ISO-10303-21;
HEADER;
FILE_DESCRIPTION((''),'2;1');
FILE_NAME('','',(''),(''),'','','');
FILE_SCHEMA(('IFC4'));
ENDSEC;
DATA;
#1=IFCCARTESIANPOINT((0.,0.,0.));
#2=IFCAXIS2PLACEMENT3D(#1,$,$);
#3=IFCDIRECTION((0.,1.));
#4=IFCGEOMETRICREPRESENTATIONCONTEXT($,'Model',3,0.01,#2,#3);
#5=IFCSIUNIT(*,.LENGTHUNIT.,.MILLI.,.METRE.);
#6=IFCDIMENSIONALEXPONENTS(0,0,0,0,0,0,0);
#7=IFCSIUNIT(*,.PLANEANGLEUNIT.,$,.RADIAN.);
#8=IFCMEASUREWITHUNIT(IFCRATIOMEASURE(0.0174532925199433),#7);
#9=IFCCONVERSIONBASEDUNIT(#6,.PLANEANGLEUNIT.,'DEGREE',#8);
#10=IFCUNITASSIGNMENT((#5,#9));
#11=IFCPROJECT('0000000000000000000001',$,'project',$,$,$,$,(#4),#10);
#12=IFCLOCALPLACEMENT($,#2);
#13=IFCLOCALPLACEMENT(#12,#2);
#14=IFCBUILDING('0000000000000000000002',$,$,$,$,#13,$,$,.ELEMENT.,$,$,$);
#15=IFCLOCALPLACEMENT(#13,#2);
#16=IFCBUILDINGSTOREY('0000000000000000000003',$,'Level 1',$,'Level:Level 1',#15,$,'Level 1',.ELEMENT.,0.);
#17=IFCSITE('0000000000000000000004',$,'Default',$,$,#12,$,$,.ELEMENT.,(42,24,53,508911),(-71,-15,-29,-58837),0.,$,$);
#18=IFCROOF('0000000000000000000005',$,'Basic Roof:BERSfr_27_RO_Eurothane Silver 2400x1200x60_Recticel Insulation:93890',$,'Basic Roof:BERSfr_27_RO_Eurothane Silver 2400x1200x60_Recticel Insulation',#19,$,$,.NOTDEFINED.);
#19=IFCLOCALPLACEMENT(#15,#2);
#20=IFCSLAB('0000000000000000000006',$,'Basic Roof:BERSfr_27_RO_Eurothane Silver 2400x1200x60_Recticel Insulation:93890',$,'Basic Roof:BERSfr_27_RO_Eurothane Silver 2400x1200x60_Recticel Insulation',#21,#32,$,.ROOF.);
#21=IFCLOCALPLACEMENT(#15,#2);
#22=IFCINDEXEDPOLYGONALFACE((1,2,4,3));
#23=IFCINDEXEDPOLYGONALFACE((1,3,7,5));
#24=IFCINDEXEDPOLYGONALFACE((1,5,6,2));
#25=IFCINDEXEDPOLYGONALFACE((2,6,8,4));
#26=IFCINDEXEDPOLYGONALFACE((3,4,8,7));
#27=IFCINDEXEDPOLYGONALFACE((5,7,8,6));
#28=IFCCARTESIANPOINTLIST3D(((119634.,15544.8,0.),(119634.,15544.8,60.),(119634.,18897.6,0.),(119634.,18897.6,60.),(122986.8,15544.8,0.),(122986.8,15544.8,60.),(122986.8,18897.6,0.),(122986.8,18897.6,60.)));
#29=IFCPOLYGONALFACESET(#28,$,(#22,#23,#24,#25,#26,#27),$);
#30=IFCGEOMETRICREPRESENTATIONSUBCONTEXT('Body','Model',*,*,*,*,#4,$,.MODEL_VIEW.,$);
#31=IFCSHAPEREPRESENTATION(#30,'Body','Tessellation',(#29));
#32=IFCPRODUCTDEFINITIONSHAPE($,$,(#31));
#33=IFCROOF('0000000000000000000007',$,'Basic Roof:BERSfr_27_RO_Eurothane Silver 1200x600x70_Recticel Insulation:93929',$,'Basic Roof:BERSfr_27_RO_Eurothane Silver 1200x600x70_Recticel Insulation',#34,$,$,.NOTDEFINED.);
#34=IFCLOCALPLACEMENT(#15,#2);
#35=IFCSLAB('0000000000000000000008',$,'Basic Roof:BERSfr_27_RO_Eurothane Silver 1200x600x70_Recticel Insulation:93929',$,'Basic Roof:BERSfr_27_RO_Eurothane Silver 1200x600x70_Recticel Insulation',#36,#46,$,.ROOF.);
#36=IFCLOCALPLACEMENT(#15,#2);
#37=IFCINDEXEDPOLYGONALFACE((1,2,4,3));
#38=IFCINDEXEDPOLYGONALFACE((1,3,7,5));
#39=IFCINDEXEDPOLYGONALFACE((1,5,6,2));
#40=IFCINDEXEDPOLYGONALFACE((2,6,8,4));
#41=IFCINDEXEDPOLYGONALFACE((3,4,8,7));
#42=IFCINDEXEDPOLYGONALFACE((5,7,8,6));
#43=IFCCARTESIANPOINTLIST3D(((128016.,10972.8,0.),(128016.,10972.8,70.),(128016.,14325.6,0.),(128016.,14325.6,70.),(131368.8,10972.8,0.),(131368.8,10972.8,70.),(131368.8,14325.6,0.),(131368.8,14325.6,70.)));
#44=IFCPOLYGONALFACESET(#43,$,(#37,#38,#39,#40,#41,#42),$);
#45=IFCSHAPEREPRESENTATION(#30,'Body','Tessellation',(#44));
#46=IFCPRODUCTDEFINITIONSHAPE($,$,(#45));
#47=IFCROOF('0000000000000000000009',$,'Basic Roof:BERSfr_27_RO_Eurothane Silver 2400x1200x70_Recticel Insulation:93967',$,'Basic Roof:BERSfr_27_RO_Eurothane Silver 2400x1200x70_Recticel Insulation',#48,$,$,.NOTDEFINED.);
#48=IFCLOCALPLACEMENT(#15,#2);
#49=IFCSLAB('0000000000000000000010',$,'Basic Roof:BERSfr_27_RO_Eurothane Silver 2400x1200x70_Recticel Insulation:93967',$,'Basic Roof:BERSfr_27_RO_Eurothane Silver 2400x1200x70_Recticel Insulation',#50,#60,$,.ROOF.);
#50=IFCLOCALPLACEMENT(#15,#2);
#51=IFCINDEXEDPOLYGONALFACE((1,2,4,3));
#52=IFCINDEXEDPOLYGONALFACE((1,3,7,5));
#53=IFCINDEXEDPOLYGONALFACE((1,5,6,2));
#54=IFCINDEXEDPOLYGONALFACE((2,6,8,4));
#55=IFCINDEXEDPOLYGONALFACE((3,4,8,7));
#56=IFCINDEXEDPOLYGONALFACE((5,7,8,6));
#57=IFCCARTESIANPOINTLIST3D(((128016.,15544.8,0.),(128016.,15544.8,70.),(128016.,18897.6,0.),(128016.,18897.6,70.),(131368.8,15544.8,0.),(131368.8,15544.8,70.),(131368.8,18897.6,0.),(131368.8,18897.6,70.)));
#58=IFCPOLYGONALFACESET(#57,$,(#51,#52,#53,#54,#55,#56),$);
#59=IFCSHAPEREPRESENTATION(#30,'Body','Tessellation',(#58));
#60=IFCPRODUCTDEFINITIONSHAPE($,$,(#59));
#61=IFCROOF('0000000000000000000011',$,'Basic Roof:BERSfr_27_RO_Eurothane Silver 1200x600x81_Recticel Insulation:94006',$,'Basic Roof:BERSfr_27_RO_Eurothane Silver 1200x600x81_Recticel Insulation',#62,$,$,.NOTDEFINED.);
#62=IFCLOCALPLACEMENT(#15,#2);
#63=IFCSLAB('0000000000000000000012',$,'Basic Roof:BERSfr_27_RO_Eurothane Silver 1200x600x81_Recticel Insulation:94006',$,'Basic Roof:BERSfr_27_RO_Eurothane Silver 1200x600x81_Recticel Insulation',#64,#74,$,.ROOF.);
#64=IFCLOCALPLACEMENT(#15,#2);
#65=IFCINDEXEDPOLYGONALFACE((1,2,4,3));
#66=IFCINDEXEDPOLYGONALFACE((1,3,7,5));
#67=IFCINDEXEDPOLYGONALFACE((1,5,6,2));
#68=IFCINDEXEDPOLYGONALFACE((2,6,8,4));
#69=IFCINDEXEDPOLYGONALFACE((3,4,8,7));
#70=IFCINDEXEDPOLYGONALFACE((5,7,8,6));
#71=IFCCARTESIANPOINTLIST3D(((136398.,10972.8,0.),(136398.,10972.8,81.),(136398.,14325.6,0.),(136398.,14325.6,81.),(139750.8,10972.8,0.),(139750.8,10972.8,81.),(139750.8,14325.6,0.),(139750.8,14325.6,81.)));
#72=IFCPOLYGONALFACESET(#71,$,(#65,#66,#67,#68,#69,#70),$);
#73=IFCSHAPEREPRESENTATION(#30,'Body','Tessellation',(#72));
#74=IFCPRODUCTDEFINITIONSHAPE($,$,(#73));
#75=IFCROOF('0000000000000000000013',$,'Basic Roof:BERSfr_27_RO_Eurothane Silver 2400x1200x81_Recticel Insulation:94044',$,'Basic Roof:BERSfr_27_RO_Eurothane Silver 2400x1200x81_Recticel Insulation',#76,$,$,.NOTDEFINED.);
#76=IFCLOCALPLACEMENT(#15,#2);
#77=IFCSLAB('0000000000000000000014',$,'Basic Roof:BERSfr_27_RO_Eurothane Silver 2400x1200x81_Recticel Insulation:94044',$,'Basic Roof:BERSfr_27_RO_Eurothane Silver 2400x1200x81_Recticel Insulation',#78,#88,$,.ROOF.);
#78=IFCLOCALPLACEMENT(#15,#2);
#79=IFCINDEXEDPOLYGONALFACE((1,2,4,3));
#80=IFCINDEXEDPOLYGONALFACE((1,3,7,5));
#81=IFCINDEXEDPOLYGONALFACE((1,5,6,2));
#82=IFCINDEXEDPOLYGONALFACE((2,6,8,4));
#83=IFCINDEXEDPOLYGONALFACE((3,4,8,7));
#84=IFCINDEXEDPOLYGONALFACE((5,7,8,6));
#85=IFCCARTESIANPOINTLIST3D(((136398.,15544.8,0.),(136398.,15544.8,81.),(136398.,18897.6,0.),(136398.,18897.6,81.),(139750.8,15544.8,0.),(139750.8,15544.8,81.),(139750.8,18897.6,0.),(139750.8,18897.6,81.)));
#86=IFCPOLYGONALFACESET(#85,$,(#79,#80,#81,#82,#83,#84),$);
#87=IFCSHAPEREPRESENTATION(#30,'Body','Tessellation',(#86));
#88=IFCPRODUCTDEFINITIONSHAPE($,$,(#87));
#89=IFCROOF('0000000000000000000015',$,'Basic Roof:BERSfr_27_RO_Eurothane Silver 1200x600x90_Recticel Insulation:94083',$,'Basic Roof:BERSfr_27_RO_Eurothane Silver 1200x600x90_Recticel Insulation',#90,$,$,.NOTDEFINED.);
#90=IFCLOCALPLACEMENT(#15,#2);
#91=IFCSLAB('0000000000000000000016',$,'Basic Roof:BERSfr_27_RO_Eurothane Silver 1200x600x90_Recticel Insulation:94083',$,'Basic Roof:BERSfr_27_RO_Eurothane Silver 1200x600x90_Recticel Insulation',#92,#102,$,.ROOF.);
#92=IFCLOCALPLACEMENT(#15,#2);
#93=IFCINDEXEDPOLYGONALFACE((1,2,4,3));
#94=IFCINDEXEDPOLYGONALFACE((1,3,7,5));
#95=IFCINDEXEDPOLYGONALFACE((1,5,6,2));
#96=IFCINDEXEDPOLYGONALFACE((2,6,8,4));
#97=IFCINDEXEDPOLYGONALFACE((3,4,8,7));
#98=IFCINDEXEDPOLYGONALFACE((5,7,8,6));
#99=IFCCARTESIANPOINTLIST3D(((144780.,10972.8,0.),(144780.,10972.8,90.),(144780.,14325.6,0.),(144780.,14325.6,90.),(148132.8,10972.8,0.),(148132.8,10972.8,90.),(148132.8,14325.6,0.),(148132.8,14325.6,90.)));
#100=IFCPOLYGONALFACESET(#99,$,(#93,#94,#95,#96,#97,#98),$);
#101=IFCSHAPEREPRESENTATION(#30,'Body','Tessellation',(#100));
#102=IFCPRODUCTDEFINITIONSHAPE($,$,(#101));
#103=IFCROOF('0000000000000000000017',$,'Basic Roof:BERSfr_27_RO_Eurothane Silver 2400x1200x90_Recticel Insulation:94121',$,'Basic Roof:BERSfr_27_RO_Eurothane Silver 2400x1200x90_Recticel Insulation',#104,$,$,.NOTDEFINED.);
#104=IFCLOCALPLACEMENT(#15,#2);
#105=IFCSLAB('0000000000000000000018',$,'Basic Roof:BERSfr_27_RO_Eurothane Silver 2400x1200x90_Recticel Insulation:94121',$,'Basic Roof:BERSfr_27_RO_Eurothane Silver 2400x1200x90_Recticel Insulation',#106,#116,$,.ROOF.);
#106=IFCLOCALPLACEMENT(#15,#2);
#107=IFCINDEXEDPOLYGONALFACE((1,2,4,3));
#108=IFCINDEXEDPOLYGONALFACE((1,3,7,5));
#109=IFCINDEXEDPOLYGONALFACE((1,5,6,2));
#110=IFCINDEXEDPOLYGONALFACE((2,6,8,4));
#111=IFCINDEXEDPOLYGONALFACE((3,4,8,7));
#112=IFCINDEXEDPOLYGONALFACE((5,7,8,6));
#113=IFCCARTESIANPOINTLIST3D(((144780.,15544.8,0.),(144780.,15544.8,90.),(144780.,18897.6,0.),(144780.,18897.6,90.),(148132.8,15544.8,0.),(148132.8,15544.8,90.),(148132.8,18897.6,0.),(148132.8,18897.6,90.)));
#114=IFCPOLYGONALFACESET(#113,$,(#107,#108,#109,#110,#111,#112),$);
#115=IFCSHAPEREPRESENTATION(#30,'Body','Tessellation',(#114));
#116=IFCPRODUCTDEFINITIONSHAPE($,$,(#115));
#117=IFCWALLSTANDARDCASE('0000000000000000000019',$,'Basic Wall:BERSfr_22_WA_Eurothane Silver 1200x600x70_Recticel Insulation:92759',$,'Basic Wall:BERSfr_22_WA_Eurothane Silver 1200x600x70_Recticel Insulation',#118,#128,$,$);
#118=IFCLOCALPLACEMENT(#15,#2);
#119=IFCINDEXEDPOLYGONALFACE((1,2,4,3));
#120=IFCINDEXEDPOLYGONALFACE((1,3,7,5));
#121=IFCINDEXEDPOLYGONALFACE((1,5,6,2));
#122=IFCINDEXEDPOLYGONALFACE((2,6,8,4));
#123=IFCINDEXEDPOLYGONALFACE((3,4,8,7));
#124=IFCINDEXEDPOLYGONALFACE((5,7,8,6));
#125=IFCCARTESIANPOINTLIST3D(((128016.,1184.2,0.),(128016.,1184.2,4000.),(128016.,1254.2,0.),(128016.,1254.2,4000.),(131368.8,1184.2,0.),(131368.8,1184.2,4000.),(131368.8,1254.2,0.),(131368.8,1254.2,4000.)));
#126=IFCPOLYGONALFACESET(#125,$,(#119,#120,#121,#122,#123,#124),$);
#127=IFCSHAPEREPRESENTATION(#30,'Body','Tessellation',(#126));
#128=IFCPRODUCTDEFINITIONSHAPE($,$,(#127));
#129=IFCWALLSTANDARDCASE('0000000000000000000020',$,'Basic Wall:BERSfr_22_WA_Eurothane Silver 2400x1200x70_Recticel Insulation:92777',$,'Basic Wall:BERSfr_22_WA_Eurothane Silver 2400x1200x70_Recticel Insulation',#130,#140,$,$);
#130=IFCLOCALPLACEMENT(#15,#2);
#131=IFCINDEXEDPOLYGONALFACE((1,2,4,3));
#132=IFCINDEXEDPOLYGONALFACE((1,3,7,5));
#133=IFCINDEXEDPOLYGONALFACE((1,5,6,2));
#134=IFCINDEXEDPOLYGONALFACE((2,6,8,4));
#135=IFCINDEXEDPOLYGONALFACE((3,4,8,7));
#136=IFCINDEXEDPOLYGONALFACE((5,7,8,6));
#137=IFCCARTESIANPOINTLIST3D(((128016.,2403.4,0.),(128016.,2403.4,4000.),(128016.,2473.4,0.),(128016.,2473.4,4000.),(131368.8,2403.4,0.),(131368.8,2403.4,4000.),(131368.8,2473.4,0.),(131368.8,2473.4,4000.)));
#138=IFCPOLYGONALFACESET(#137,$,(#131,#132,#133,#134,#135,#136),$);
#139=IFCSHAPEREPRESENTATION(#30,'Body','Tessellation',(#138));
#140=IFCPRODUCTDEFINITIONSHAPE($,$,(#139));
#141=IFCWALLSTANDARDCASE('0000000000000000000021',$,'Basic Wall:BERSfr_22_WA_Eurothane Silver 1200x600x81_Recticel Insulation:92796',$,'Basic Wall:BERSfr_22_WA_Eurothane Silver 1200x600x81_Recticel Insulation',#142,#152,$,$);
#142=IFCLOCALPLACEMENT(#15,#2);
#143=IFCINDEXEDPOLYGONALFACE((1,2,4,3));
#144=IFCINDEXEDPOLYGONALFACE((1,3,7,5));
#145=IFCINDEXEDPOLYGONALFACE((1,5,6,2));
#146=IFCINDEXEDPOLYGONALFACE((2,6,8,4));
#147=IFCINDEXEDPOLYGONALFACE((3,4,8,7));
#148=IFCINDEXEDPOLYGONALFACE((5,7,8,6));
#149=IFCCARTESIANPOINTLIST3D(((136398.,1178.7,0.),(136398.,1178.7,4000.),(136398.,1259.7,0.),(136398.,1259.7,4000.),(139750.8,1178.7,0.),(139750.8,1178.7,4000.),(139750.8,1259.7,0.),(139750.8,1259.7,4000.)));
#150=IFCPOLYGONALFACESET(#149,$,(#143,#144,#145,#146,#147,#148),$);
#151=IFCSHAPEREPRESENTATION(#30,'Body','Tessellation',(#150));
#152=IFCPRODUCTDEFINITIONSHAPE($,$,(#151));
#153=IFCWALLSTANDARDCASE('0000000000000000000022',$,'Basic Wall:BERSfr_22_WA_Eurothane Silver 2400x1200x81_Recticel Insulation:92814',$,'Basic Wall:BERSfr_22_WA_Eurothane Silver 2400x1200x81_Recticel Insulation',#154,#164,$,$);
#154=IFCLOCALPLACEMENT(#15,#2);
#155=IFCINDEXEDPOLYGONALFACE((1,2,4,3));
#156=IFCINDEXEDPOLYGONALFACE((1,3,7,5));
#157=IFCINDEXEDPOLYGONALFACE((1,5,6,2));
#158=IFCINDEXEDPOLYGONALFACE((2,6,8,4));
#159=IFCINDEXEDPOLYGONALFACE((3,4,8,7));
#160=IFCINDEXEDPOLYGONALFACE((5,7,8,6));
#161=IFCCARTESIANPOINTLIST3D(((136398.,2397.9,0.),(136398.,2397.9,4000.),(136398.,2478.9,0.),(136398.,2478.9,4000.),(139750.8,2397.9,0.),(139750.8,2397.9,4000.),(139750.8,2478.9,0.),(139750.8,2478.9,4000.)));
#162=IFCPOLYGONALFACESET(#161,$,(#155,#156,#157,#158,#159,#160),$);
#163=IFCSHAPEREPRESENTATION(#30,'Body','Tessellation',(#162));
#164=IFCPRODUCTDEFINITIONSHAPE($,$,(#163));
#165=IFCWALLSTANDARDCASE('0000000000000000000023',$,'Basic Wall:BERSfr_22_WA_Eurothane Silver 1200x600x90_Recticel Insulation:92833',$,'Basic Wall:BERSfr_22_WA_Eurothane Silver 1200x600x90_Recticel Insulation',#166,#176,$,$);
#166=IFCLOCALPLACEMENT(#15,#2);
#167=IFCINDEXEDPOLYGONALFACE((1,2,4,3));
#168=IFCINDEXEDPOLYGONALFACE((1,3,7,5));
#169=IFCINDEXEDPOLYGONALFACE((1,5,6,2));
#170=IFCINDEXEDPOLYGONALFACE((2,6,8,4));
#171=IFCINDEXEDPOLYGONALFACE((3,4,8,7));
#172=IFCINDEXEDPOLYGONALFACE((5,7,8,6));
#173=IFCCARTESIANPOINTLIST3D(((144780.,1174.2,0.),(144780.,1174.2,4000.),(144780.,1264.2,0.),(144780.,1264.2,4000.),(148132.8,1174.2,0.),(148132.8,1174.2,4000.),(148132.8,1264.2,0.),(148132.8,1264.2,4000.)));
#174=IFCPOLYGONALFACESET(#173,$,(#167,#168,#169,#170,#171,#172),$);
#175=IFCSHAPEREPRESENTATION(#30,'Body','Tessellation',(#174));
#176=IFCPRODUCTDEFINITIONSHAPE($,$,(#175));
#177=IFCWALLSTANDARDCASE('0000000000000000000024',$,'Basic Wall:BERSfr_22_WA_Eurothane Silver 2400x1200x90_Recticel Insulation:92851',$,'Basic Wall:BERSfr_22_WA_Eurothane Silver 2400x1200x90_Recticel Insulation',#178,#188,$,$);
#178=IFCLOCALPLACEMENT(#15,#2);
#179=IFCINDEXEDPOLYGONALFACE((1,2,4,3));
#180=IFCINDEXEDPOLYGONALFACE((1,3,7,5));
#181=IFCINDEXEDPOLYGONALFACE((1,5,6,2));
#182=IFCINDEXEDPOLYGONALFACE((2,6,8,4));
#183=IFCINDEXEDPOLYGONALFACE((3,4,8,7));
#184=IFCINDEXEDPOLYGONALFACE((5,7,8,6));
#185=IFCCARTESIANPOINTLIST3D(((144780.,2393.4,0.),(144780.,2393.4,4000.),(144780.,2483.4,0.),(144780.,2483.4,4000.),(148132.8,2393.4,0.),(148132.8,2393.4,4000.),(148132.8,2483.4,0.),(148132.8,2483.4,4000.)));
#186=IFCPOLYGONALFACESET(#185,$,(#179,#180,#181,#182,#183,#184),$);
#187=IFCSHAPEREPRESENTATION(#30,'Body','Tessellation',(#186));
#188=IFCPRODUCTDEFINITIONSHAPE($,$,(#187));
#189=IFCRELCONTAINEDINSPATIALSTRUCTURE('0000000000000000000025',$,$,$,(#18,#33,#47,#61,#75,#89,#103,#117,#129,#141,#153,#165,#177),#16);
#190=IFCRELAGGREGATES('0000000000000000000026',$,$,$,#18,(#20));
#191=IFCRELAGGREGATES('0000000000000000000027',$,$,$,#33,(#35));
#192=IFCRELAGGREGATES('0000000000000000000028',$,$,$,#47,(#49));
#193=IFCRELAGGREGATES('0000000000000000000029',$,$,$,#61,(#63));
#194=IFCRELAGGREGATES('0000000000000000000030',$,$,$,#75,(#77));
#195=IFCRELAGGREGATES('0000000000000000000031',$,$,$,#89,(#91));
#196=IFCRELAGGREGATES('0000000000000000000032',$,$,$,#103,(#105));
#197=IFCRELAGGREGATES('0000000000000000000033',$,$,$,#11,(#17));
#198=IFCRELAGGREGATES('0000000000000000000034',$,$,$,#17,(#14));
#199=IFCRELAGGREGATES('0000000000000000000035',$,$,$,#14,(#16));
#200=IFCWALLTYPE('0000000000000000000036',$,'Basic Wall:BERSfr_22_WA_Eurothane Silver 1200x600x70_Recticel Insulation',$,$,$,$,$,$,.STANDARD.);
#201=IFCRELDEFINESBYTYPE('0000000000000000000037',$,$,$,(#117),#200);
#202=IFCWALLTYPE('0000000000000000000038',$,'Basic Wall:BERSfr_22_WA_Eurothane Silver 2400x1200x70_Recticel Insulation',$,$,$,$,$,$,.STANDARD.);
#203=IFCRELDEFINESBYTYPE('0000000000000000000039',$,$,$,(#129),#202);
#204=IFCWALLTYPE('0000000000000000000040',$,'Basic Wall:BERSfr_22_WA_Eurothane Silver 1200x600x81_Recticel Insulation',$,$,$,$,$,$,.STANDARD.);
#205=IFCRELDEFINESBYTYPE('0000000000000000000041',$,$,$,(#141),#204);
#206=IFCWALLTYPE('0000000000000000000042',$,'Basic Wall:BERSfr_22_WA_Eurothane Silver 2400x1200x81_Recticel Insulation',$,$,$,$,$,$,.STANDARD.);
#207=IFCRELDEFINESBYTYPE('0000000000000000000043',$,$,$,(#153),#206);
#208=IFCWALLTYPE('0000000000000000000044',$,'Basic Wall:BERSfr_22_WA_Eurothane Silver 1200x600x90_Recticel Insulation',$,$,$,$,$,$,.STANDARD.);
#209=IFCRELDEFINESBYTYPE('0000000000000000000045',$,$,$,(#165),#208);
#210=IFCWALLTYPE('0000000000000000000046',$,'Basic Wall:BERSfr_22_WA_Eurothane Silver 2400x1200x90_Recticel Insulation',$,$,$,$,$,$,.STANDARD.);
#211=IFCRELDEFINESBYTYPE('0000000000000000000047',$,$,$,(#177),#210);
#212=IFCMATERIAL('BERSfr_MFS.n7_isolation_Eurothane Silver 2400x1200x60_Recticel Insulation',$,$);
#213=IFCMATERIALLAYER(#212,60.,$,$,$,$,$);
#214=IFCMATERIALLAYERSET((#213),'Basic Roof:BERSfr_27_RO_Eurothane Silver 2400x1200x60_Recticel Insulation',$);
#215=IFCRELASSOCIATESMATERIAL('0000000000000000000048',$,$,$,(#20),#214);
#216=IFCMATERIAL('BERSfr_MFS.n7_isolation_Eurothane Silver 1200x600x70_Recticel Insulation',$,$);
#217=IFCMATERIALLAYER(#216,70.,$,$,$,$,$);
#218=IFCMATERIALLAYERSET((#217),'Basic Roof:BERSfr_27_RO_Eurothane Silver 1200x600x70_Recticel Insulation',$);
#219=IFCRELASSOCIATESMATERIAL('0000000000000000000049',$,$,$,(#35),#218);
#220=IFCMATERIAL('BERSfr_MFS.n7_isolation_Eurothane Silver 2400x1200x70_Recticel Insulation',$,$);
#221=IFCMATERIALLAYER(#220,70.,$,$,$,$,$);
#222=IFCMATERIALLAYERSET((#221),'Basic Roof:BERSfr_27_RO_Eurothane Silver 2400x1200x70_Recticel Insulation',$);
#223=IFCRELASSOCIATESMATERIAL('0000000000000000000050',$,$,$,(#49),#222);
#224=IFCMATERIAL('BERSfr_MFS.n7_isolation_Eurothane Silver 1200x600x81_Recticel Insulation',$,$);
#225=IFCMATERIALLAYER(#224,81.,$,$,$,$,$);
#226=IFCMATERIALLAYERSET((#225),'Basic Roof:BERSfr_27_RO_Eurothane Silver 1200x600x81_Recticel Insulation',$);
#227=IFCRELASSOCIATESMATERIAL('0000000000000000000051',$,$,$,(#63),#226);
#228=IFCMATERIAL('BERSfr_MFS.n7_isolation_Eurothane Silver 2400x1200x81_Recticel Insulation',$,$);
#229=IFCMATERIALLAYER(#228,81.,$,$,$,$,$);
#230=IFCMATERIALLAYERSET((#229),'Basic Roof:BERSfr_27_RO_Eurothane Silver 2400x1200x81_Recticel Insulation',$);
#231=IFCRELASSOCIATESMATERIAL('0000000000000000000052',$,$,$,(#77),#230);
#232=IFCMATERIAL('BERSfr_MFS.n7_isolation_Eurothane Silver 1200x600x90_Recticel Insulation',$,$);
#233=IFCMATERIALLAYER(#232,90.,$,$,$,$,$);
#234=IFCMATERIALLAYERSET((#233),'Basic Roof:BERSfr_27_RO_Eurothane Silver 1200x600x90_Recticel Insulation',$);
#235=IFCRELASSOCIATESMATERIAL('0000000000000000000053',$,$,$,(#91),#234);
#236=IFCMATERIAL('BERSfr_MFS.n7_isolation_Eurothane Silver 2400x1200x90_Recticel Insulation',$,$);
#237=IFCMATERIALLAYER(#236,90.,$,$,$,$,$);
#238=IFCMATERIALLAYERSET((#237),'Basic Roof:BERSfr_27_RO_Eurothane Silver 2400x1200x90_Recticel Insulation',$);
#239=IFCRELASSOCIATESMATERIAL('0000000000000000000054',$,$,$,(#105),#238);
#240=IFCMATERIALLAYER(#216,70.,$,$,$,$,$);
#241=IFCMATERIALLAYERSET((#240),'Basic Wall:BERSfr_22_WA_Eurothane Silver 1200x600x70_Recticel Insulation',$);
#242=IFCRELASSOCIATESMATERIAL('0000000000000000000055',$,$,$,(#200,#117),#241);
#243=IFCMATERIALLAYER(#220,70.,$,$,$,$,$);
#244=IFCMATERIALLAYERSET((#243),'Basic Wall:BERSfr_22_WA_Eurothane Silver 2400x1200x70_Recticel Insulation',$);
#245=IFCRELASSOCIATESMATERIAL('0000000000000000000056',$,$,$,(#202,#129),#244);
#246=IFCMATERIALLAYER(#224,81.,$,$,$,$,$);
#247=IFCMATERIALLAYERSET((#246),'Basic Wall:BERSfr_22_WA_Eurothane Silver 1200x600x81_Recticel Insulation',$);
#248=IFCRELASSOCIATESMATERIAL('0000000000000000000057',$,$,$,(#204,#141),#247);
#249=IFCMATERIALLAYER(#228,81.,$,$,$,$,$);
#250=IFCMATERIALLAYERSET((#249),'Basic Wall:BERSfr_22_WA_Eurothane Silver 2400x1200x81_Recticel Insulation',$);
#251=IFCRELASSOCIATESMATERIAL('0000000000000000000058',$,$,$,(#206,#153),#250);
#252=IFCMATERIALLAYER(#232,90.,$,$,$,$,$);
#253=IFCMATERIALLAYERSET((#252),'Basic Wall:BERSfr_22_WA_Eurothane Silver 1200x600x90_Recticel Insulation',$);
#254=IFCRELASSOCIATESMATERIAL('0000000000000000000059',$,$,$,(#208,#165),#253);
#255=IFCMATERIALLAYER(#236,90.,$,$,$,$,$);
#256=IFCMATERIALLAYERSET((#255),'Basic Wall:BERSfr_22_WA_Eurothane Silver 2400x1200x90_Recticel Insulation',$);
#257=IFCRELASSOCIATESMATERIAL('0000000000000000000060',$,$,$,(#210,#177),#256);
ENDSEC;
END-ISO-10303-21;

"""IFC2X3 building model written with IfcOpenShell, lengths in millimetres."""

from ifc_helpers import new_model, entity, si_unit, converted_unit, direction, frame, frame_2d, origin, place, context, subcontext, project, spatial, rectangle, extrude, material, layer, layer_set, layer_usage, type_object, element, aggregate, save


model = new_model("IFC2X3")

# Units and contexts
model_context = context("Model", 3, precision=0.01, world=origin(), true_north=direction((0.0, 1.0)))
body_context = subcontext(model_context, "Body", "Model", "MODEL_VIEW")
ifc_project = project(units=[si_unit("LENGTHUNIT", "METRE", prefix="MILLI"), converted_unit("PLANEANGLEUNIT", "DEGREE", entity("IfcRatioMeasure", 0.0174532925199433), si_unit("PLANEANGLEUNIT", "RADIAN"), dimensions=[0, 0, 0, 0, 0, 0, 0])], contexts=[model_context])

# Site, building, storey
site_placement = place(None, origin())
site = spatial("IfcSite", under=ifc_project, at=site_placement, Name="Default", CompositionType="ELEMENT", RefLatitude=(42, 24, 53, 508911), RefLongitude=(-71, -15, -29, -58837), RefElevation=0.0)
building_placement = place(site_placement, origin())
building = spatial("IfcBuilding", under=site, at=building_placement, CompositionType="ELEMENT")
storey_placement = place(building_placement, origin())
storey = spatial("IfcBuildingStorey", under=building, at=storey_placement, Name="Level 1", ObjectType="Level:Level 1", LongName="Level 1", CompositionType="ELEMENT", Elevation=0.0)

# Roofs, slabs
roof_1_placement = place(storey_placement, frame((119634.0, 15544.8, 0.0)))
roof_1 = element("IfcRoof", 1, at=roof_1_placement, inside=storey, Name="Basic Roof:BERSfr_27_RO_Eurothane Silver 2400x1200x60_Recticel Insulation:93890", ObjectType="Basic Roof:BERSfr_27_RO_Eurothane Silver 2400x1200x60_Recticel Insulation", ShapeType="NOTDEFINED")
ifc_material_1 = material(Name="BERSfr_MFS.n7_isolation_Eurothane Silver 2400x1200x60_Recticel Insulation")
ifc_layer_1 = layer(ifc_material_1, 60.0)
ifc_layer_set_1 = layer_set([ifc_layer_1], Name="Basic Roof:BERSfr_27_RO_Eurothane Silver 2400x1200x60_Recticel Insulation")
slab_1_placement = place(roof_1_placement, origin())
slab_1 = element("IfcSlab", 2, at=slab_1_placement, material=ifc_layer_set_1, Name="Basic Roof:BERSfr_27_RO_Eurothane Silver 2400x1200x60_Recticel Insulation:93890", ObjectType="Basic Roof:BERSfr_27_RO_Eurothane Silver 2400x1200x60_Recticel Insulation", PredefinedType="ROOF", context=body_context, shape_type="SweptSolid", body=[
    extrude(rectangle(XDim=3352.8, YDim=3352.8, at=frame_2d((0.0, 0.0), x_axis=(-1.0, 0.0))), frame((1676.4, 1676.4, 0.0)), (0.0, 0.0, 1.0), 60.0),
])
aggregate(roof_1, [slab_1])
roof_2_placement = place(storey_placement, frame((128016.0, 10972.8, 0.0)))
roof_2 = element("IfcRoof", 3, at=roof_2_placement, inside=storey, Name="Basic Roof:BERSfr_27_RO_Eurothane Silver 1200x600x70_Recticel Insulation:93929", ObjectType="Basic Roof:BERSfr_27_RO_Eurothane Silver 1200x600x70_Recticel Insulation", ShapeType="NOTDEFINED")
ifc_material_2 = material(Name="BERSfr_MFS.n7_isolation_Eurothane Silver 1200x600x70_Recticel Insulation")
ifc_layer_2 = layer(ifc_material_2, 70.0)
ifc_layer_set_2 = layer_set([ifc_layer_2], Name="Basic Roof:BERSfr_27_RO_Eurothane Silver 1200x600x70_Recticel Insulation")
slab_2_placement = place(roof_2_placement, origin())
slab_2 = element("IfcSlab", 4, at=slab_2_placement, material=ifc_layer_set_2, Name="Basic Roof:BERSfr_27_RO_Eurothane Silver 1200x600x70_Recticel Insulation:93929", ObjectType="Basic Roof:BERSfr_27_RO_Eurothane Silver 1200x600x70_Recticel Insulation", PredefinedType="ROOF", context=body_context, shape_type="SweptSolid", body=[
    extrude(rectangle(XDim=3352.8, YDim=3352.8, at=frame_2d((0.0, 0.0), x_axis=(-1.0, 0.0))), frame((1676.4, 1676.4, 0.0)), (0.0, 0.0, 1.0), 70.0),
])
aggregate(roof_2, [slab_2])
roof_3_placement = place(storey_placement, frame((128016.0, 15544.8, 0.0)))
roof_3 = element("IfcRoof", 5, at=roof_3_placement, inside=storey, Name="Basic Roof:BERSfr_27_RO_Eurothane Silver 2400x1200x70_Recticel Insulation:93967", ObjectType="Basic Roof:BERSfr_27_RO_Eurothane Silver 2400x1200x70_Recticel Insulation", ShapeType="NOTDEFINED")
ifc_material_3 = material(Name="BERSfr_MFS.n7_isolation_Eurothane Silver 2400x1200x70_Recticel Insulation")
ifc_layer_3 = layer(ifc_material_3, 70.0)
ifc_layer_set_3 = layer_set([ifc_layer_3], Name="Basic Roof:BERSfr_27_RO_Eurothane Silver 2400x1200x70_Recticel Insulation")
slab_3_placement = place(roof_3_placement, origin())
slab_3 = element("IfcSlab", 6, at=slab_3_placement, material=ifc_layer_set_3, Name="Basic Roof:BERSfr_27_RO_Eurothane Silver 2400x1200x70_Recticel Insulation:93967", ObjectType="Basic Roof:BERSfr_27_RO_Eurothane Silver 2400x1200x70_Recticel Insulation", PredefinedType="ROOF", context=body_context, shape_type="SweptSolid", body=[
    extrude(rectangle(XDim=3352.8, YDim=3352.8, at=frame_2d((0.0, 0.0), x_axis=(-1.0, 0.0))), frame((1676.4, 1676.4, 0.0)), (0.0, 0.0, 1.0), 70.0),
])
aggregate(roof_3, [slab_3])
roof_4_placement = place(storey_placement, frame((136398.0, 10972.8, 0.0)))
roof_4 = element("IfcRoof", 7, at=roof_4_placement, inside=storey, Name="Basic Roof:BERSfr_27_RO_Eurothane Silver 1200x600x81_Recticel Insulation:94006", ObjectType="Basic Roof:BERSfr_27_RO_Eurothane Silver 1200x600x81_Recticel Insulation", ShapeType="NOTDEFINED")
ifc_material_4 = material(Name="BERSfr_MFS.n7_isolation_Eurothane Silver 1200x600x81_Recticel Insulation")
ifc_layer_4 = layer(ifc_material_4, 81.0)
ifc_layer_set_4 = layer_set([ifc_layer_4], Name="Basic Roof:BERSfr_27_RO_Eurothane Silver 1200x600x81_Recticel Insulation")
slab_4_placement = place(roof_4_placement, origin())
slab_4 = element("IfcSlab", 8, at=slab_4_placement, material=ifc_layer_set_4, Name="Basic Roof:BERSfr_27_RO_Eurothane Silver 1200x600x81_Recticel Insulation:94006", ObjectType="Basic Roof:BERSfr_27_RO_Eurothane Silver 1200x600x81_Recticel Insulation", PredefinedType="ROOF", context=body_context, shape_type="SweptSolid", body=[
    extrude(rectangle(XDim=3352.8, YDim=3352.8, at=frame_2d((0.0, 0.0), x_axis=(-1.0, 0.0))), frame((1676.4, 1676.4, 0.0)), (0.0, 0.0, 1.0), 81.0),
])
aggregate(roof_4, [slab_4])
roof_5_placement = place(storey_placement, frame((136398.0, 15544.8, 0.0)))
roof_5 = element("IfcRoof", 9, at=roof_5_placement, inside=storey, Name="Basic Roof:BERSfr_27_RO_Eurothane Silver 2400x1200x81_Recticel Insulation:94044", ObjectType="Basic Roof:BERSfr_27_RO_Eurothane Silver 2400x1200x81_Recticel Insulation", ShapeType="NOTDEFINED")
ifc_material_5 = material(Name="BERSfr_MFS.n7_isolation_Eurothane Silver 2400x1200x81_Recticel Insulation")
ifc_layer_5 = layer(ifc_material_5, 81.0)
ifc_layer_set_5 = layer_set([ifc_layer_5], Name="Basic Roof:BERSfr_27_RO_Eurothane Silver 2400x1200x81_Recticel Insulation")
slab_5_placement = place(roof_5_placement, origin())
slab_5 = element("IfcSlab", 10, at=slab_5_placement, material=ifc_layer_set_5, Name="Basic Roof:BERSfr_27_RO_Eurothane Silver 2400x1200x81_Recticel Insulation:94044", ObjectType="Basic Roof:BERSfr_27_RO_Eurothane Silver 2400x1200x81_Recticel Insulation", PredefinedType="ROOF", context=body_context, shape_type="SweptSolid", body=[
    extrude(rectangle(XDim=3352.8, YDim=3352.8, at=frame_2d((0.0, 0.0), x_axis=(-1.0, 0.0))), frame((1676.4, 1676.4, 0.0)), (0.0, 0.0, 1.0), 81.0),
])
aggregate(roof_5, [slab_5])
roof_6_placement = place(storey_placement, frame((144780.0, 10972.8, 0.0)))
roof_6 = element("IfcRoof", 11, at=roof_6_placement, inside=storey, Name="Basic Roof:BERSfr_27_RO_Eurothane Silver 1200x600x90_Recticel Insulation:94083", ObjectType="Basic Roof:BERSfr_27_RO_Eurothane Silver 1200x600x90_Recticel Insulation", ShapeType="NOTDEFINED")
ifc_material_6 = material(Name="BERSfr_MFS.n7_isolation_Eurothane Silver 1200x600x90_Recticel Insulation")
ifc_layer_6 = layer(ifc_material_6, 90.0)
ifc_layer_set_6 = layer_set([ifc_layer_6], Name="Basic Roof:BERSfr_27_RO_Eurothane Silver 1200x600x90_Recticel Insulation")
slab_6_placement = place(roof_6_placement, origin())
slab_6 = element("IfcSlab", 12, at=slab_6_placement, material=ifc_layer_set_6, Name="Basic Roof:BERSfr_27_RO_Eurothane Silver 1200x600x90_Recticel Insulation:94083", ObjectType="Basic Roof:BERSfr_27_RO_Eurothane Silver 1200x600x90_Recticel Insulation", PredefinedType="ROOF", context=body_context, shape_type="SweptSolid", body=[
    extrude(rectangle(XDim=3352.8, YDim=3352.8, at=frame_2d((0.0, 0.0), x_axis=(-1.0, 0.0))), frame((1676.4, 1676.4, 0.0)), (0.0, 0.0, 1.0), 90.0),
])
aggregate(roof_6, [slab_6])
roof_7_placement = place(storey_placement, frame((144780.0, 15544.8, 0.0)))
roof_7 = element("IfcRoof", 13, at=roof_7_placement, inside=storey, Name="Basic Roof:BERSfr_27_RO_Eurothane Silver 2400x1200x90_Recticel Insulation:94121", ObjectType="Basic Roof:BERSfr_27_RO_Eurothane Silver 2400x1200x90_Recticel Insulation", ShapeType="NOTDEFINED")
ifc_material_7 = material(Name="BERSfr_MFS.n7_isolation_Eurothane Silver 2400x1200x90_Recticel Insulation")
ifc_layer_7 = layer(ifc_material_7, 90.0)
ifc_layer_set_7 = layer_set([ifc_layer_7], Name="Basic Roof:BERSfr_27_RO_Eurothane Silver 2400x1200x90_Recticel Insulation")
slab_7_placement = place(roof_7_placement, origin())
slab_7 = element("IfcSlab", 14, at=slab_7_placement, material=ifc_layer_set_7, Name="Basic Roof:BERSfr_27_RO_Eurothane Silver 2400x1200x90_Recticel Insulation:94121", ObjectType="Basic Roof:BERSfr_27_RO_Eurothane Silver 2400x1200x90_Recticel Insulation", PredefinedType="ROOF", context=body_context, shape_type="SweptSolid", body=[
    extrude(rectangle(XDim=3352.8, YDim=3352.8, at=frame_2d((0.0, 0.0), x_axis=(-1.0, 0.0))), frame((1676.4, 1676.4, 0.0)), (0.0, 0.0, 1.0), 90.0),
])
aggregate(roof_7, [slab_7])

# Walls
ifc_layer_8 = layer(ifc_material_2, 70.0)
ifc_layer_set_8 = layer_set([ifc_layer_8], Name="Basic Wall:BERSfr_22_WA_Eurothane Silver 1200x600x70_Recticel Insulation")
ifc_layer_usage_1 = layer_usage(ifc_layer_set_8, "AXIS2", "NEGATIVE", 35.0)
wall_type_1 = type_object("IfcWallType", Name="Basic Wall:BERSfr_22_WA_Eurothane Silver 1200x600x70_Recticel Insulation", PredefinedType="STANDARD", material=ifc_layer_set_8)
wall_1_placement = place(storey_placement, frame((128016.0, 1219.2, 0.0)))
element("IfcWallStandardCase", 15, at=wall_1_placement, inside=storey, type_object=wall_type_1, material=ifc_layer_usage_1, Name="Basic Wall:BERSfr_22_WA_Eurothane Silver 1200x600x70_Recticel Insulation:92759", ObjectType="Basic Wall:BERSfr_22_WA_Eurothane Silver 1200x600x70_Recticel Insulation", context=body_context, shape_type="SweptSolid", body=[
    extrude(rectangle(XDim=3352.8, YDim=70.0, at=frame_2d((1676.4, 0.0), x_axis=(-1.0, 0.0))), origin(), (0.0, 0.0, 1.0), 4000.0),
])
ifc_layer_9 = layer(ifc_material_3, 70.0)
ifc_layer_set_9 = layer_set([ifc_layer_9], Name="Basic Wall:BERSfr_22_WA_Eurothane Silver 2400x1200x70_Recticel Insulation")
ifc_layer_usage_2 = layer_usage(ifc_layer_set_9, "AXIS2", "NEGATIVE", 35.0)
wall_type_2 = type_object("IfcWallType", Name="Basic Wall:BERSfr_22_WA_Eurothane Silver 2400x1200x70_Recticel Insulation", PredefinedType="STANDARD", material=ifc_layer_set_9)
wall_2_placement = place(storey_placement, frame((128016.0, 2438.4, 0.0)))
element("IfcWallStandardCase", 16, at=wall_2_placement, inside=storey, type_object=wall_type_2, material=ifc_layer_usage_2, Name="Basic Wall:BERSfr_22_WA_Eurothane Silver 2400x1200x70_Recticel Insulation:92777", ObjectType="Basic Wall:BERSfr_22_WA_Eurothane Silver 2400x1200x70_Recticel Insulation", context=body_context, shape_type="SweptSolid", body=[
    extrude(rectangle(XDim=3352.8, YDim=70.0, at=frame_2d((1676.4, 0.0), x_axis=(-1.0, 0.0))), origin(), (0.0, 0.0, 1.0), 4000.0),
])
ifc_layer_10 = layer(ifc_material_4, 81.0)
ifc_layer_set_10 = layer_set([ifc_layer_10], Name="Basic Wall:BERSfr_22_WA_Eurothane Silver 1200x600x81_Recticel Insulation")
ifc_layer_usage_3 = layer_usage(ifc_layer_set_10, "AXIS2", "NEGATIVE", 40.5)
wall_type_3 = type_object("IfcWallType", Name="Basic Wall:BERSfr_22_WA_Eurothane Silver 1200x600x81_Recticel Insulation", PredefinedType="STANDARD", material=ifc_layer_set_10)
wall_3_placement = place(storey_placement, frame((136398.0, 1219.2, 0.0)))
element("IfcWallStandardCase", 17, at=wall_3_placement, inside=storey, type_object=wall_type_3, material=ifc_layer_usage_3, Name="Basic Wall:BERSfr_22_WA_Eurothane Silver 1200x600x81_Recticel Insulation:92796", ObjectType="Basic Wall:BERSfr_22_WA_Eurothane Silver 1200x600x81_Recticel Insulation", context=body_context, shape_type="SweptSolid", body=[
    extrude(rectangle(XDim=3352.8, YDim=81.0, at=frame_2d((1676.4, 0.0), x_axis=(-1.0, 0.0))), origin(), (0.0, 0.0, 1.0), 4000.0),
])
ifc_layer_11 = layer(ifc_material_5, 81.0)
ifc_layer_set_11 = layer_set([ifc_layer_11], Name="Basic Wall:BERSfr_22_WA_Eurothane Silver 2400x1200x81_Recticel Insulation")
ifc_layer_usage_4 = layer_usage(ifc_layer_set_11, "AXIS2", "NEGATIVE", 40.5)
wall_type_4 = type_object("IfcWallType", Name="Basic Wall:BERSfr_22_WA_Eurothane Silver 2400x1200x81_Recticel Insulation", PredefinedType="STANDARD", material=ifc_layer_set_11)
wall_4_placement = place(storey_placement, frame((136398.0, 2438.4, 0.0)))
element("IfcWallStandardCase", 18, at=wall_4_placement, inside=storey, type_object=wall_type_4, material=ifc_layer_usage_4, Name="Basic Wall:BERSfr_22_WA_Eurothane Silver 2400x1200x81_Recticel Insulation:92814", ObjectType="Basic Wall:BERSfr_22_WA_Eurothane Silver 2400x1200x81_Recticel Insulation", context=body_context, shape_type="SweptSolid", body=[
    extrude(rectangle(XDim=3352.8, YDim=81.0, at=frame_2d((1676.4, 0.0), x_axis=(-1.0, 0.0))), origin(), (0.0, 0.0, 1.0), 4000.0),
])
ifc_layer_12 = layer(ifc_material_6, 90.0)
ifc_layer_set_12 = layer_set([ifc_layer_12], Name="Basic Wall:BERSfr_22_WA_Eurothane Silver 1200x600x90_Recticel Insulation")
ifc_layer_usage_5 = layer_usage(ifc_layer_set_12, "AXIS2", "NEGATIVE", 45.0)
wall_type_5 = type_object("IfcWallType", Name="Basic Wall:BERSfr_22_WA_Eurothane Silver 1200x600x90_Recticel Insulation", PredefinedType="STANDARD", material=ifc_layer_set_12)
wall_5_placement = place(storey_placement, frame((144780.0, 1219.2, 0.0)))
element("IfcWallStandardCase", 19, at=wall_5_placement, inside=storey, type_object=wall_type_5, material=ifc_layer_usage_5, Name="Basic Wall:BERSfr_22_WA_Eurothane Silver 1200x600x90_Recticel Insulation:92833", ObjectType="Basic Wall:BERSfr_22_WA_Eurothane Silver 1200x600x90_Recticel Insulation", context=body_context, shape_type="SweptSolid", body=[
    extrude(rectangle(XDim=3352.8, YDim=90.0, at=frame_2d((1676.4, 0.0), x_axis=(-1.0, 0.0))), origin(), (0.0, 0.0, 1.0), 4000.0),
])
ifc_layer_13 = layer(ifc_material_7, 90.0)
ifc_layer_set_13 = layer_set([ifc_layer_13], Name="Basic Wall:BERSfr_22_WA_Eurothane Silver 2400x1200x90_Recticel Insulation")
ifc_layer_usage_6 = layer_usage(ifc_layer_set_13, "AXIS2", "NEGATIVE", 45.0)
wall_type_6 = type_object("IfcWallType", Name="Basic Wall:BERSfr_22_WA_Eurothane Silver 2400x1200x90_Recticel Insulation", PredefinedType="STANDARD", material=ifc_layer_set_13)
wall_6_placement = place(storey_placement, frame((144780.0, 2438.4, 0.0)))
element("IfcWallStandardCase", 20, at=wall_6_placement, inside=storey, type_object=wall_type_6, material=ifc_layer_usage_6, Name="Basic Wall:BERSfr_22_WA_Eurothane Silver 2400x1200x90_Recticel Insulation:92851", ObjectType="Basic Wall:BERSfr_22_WA_Eurothane Silver 2400x1200x90_Recticel Insulation", context=body_context, shape_type="SweptSolid", body=[
    extrude(rectangle(XDim=3352.8, YDim=90.0, at=frame_2d((1676.4, 0.0), x_axis=(-1.0, 0.0))), origin(), (0.0, 0.0, 1.0), 4000.0),
])

save(model, "model.ifc")
